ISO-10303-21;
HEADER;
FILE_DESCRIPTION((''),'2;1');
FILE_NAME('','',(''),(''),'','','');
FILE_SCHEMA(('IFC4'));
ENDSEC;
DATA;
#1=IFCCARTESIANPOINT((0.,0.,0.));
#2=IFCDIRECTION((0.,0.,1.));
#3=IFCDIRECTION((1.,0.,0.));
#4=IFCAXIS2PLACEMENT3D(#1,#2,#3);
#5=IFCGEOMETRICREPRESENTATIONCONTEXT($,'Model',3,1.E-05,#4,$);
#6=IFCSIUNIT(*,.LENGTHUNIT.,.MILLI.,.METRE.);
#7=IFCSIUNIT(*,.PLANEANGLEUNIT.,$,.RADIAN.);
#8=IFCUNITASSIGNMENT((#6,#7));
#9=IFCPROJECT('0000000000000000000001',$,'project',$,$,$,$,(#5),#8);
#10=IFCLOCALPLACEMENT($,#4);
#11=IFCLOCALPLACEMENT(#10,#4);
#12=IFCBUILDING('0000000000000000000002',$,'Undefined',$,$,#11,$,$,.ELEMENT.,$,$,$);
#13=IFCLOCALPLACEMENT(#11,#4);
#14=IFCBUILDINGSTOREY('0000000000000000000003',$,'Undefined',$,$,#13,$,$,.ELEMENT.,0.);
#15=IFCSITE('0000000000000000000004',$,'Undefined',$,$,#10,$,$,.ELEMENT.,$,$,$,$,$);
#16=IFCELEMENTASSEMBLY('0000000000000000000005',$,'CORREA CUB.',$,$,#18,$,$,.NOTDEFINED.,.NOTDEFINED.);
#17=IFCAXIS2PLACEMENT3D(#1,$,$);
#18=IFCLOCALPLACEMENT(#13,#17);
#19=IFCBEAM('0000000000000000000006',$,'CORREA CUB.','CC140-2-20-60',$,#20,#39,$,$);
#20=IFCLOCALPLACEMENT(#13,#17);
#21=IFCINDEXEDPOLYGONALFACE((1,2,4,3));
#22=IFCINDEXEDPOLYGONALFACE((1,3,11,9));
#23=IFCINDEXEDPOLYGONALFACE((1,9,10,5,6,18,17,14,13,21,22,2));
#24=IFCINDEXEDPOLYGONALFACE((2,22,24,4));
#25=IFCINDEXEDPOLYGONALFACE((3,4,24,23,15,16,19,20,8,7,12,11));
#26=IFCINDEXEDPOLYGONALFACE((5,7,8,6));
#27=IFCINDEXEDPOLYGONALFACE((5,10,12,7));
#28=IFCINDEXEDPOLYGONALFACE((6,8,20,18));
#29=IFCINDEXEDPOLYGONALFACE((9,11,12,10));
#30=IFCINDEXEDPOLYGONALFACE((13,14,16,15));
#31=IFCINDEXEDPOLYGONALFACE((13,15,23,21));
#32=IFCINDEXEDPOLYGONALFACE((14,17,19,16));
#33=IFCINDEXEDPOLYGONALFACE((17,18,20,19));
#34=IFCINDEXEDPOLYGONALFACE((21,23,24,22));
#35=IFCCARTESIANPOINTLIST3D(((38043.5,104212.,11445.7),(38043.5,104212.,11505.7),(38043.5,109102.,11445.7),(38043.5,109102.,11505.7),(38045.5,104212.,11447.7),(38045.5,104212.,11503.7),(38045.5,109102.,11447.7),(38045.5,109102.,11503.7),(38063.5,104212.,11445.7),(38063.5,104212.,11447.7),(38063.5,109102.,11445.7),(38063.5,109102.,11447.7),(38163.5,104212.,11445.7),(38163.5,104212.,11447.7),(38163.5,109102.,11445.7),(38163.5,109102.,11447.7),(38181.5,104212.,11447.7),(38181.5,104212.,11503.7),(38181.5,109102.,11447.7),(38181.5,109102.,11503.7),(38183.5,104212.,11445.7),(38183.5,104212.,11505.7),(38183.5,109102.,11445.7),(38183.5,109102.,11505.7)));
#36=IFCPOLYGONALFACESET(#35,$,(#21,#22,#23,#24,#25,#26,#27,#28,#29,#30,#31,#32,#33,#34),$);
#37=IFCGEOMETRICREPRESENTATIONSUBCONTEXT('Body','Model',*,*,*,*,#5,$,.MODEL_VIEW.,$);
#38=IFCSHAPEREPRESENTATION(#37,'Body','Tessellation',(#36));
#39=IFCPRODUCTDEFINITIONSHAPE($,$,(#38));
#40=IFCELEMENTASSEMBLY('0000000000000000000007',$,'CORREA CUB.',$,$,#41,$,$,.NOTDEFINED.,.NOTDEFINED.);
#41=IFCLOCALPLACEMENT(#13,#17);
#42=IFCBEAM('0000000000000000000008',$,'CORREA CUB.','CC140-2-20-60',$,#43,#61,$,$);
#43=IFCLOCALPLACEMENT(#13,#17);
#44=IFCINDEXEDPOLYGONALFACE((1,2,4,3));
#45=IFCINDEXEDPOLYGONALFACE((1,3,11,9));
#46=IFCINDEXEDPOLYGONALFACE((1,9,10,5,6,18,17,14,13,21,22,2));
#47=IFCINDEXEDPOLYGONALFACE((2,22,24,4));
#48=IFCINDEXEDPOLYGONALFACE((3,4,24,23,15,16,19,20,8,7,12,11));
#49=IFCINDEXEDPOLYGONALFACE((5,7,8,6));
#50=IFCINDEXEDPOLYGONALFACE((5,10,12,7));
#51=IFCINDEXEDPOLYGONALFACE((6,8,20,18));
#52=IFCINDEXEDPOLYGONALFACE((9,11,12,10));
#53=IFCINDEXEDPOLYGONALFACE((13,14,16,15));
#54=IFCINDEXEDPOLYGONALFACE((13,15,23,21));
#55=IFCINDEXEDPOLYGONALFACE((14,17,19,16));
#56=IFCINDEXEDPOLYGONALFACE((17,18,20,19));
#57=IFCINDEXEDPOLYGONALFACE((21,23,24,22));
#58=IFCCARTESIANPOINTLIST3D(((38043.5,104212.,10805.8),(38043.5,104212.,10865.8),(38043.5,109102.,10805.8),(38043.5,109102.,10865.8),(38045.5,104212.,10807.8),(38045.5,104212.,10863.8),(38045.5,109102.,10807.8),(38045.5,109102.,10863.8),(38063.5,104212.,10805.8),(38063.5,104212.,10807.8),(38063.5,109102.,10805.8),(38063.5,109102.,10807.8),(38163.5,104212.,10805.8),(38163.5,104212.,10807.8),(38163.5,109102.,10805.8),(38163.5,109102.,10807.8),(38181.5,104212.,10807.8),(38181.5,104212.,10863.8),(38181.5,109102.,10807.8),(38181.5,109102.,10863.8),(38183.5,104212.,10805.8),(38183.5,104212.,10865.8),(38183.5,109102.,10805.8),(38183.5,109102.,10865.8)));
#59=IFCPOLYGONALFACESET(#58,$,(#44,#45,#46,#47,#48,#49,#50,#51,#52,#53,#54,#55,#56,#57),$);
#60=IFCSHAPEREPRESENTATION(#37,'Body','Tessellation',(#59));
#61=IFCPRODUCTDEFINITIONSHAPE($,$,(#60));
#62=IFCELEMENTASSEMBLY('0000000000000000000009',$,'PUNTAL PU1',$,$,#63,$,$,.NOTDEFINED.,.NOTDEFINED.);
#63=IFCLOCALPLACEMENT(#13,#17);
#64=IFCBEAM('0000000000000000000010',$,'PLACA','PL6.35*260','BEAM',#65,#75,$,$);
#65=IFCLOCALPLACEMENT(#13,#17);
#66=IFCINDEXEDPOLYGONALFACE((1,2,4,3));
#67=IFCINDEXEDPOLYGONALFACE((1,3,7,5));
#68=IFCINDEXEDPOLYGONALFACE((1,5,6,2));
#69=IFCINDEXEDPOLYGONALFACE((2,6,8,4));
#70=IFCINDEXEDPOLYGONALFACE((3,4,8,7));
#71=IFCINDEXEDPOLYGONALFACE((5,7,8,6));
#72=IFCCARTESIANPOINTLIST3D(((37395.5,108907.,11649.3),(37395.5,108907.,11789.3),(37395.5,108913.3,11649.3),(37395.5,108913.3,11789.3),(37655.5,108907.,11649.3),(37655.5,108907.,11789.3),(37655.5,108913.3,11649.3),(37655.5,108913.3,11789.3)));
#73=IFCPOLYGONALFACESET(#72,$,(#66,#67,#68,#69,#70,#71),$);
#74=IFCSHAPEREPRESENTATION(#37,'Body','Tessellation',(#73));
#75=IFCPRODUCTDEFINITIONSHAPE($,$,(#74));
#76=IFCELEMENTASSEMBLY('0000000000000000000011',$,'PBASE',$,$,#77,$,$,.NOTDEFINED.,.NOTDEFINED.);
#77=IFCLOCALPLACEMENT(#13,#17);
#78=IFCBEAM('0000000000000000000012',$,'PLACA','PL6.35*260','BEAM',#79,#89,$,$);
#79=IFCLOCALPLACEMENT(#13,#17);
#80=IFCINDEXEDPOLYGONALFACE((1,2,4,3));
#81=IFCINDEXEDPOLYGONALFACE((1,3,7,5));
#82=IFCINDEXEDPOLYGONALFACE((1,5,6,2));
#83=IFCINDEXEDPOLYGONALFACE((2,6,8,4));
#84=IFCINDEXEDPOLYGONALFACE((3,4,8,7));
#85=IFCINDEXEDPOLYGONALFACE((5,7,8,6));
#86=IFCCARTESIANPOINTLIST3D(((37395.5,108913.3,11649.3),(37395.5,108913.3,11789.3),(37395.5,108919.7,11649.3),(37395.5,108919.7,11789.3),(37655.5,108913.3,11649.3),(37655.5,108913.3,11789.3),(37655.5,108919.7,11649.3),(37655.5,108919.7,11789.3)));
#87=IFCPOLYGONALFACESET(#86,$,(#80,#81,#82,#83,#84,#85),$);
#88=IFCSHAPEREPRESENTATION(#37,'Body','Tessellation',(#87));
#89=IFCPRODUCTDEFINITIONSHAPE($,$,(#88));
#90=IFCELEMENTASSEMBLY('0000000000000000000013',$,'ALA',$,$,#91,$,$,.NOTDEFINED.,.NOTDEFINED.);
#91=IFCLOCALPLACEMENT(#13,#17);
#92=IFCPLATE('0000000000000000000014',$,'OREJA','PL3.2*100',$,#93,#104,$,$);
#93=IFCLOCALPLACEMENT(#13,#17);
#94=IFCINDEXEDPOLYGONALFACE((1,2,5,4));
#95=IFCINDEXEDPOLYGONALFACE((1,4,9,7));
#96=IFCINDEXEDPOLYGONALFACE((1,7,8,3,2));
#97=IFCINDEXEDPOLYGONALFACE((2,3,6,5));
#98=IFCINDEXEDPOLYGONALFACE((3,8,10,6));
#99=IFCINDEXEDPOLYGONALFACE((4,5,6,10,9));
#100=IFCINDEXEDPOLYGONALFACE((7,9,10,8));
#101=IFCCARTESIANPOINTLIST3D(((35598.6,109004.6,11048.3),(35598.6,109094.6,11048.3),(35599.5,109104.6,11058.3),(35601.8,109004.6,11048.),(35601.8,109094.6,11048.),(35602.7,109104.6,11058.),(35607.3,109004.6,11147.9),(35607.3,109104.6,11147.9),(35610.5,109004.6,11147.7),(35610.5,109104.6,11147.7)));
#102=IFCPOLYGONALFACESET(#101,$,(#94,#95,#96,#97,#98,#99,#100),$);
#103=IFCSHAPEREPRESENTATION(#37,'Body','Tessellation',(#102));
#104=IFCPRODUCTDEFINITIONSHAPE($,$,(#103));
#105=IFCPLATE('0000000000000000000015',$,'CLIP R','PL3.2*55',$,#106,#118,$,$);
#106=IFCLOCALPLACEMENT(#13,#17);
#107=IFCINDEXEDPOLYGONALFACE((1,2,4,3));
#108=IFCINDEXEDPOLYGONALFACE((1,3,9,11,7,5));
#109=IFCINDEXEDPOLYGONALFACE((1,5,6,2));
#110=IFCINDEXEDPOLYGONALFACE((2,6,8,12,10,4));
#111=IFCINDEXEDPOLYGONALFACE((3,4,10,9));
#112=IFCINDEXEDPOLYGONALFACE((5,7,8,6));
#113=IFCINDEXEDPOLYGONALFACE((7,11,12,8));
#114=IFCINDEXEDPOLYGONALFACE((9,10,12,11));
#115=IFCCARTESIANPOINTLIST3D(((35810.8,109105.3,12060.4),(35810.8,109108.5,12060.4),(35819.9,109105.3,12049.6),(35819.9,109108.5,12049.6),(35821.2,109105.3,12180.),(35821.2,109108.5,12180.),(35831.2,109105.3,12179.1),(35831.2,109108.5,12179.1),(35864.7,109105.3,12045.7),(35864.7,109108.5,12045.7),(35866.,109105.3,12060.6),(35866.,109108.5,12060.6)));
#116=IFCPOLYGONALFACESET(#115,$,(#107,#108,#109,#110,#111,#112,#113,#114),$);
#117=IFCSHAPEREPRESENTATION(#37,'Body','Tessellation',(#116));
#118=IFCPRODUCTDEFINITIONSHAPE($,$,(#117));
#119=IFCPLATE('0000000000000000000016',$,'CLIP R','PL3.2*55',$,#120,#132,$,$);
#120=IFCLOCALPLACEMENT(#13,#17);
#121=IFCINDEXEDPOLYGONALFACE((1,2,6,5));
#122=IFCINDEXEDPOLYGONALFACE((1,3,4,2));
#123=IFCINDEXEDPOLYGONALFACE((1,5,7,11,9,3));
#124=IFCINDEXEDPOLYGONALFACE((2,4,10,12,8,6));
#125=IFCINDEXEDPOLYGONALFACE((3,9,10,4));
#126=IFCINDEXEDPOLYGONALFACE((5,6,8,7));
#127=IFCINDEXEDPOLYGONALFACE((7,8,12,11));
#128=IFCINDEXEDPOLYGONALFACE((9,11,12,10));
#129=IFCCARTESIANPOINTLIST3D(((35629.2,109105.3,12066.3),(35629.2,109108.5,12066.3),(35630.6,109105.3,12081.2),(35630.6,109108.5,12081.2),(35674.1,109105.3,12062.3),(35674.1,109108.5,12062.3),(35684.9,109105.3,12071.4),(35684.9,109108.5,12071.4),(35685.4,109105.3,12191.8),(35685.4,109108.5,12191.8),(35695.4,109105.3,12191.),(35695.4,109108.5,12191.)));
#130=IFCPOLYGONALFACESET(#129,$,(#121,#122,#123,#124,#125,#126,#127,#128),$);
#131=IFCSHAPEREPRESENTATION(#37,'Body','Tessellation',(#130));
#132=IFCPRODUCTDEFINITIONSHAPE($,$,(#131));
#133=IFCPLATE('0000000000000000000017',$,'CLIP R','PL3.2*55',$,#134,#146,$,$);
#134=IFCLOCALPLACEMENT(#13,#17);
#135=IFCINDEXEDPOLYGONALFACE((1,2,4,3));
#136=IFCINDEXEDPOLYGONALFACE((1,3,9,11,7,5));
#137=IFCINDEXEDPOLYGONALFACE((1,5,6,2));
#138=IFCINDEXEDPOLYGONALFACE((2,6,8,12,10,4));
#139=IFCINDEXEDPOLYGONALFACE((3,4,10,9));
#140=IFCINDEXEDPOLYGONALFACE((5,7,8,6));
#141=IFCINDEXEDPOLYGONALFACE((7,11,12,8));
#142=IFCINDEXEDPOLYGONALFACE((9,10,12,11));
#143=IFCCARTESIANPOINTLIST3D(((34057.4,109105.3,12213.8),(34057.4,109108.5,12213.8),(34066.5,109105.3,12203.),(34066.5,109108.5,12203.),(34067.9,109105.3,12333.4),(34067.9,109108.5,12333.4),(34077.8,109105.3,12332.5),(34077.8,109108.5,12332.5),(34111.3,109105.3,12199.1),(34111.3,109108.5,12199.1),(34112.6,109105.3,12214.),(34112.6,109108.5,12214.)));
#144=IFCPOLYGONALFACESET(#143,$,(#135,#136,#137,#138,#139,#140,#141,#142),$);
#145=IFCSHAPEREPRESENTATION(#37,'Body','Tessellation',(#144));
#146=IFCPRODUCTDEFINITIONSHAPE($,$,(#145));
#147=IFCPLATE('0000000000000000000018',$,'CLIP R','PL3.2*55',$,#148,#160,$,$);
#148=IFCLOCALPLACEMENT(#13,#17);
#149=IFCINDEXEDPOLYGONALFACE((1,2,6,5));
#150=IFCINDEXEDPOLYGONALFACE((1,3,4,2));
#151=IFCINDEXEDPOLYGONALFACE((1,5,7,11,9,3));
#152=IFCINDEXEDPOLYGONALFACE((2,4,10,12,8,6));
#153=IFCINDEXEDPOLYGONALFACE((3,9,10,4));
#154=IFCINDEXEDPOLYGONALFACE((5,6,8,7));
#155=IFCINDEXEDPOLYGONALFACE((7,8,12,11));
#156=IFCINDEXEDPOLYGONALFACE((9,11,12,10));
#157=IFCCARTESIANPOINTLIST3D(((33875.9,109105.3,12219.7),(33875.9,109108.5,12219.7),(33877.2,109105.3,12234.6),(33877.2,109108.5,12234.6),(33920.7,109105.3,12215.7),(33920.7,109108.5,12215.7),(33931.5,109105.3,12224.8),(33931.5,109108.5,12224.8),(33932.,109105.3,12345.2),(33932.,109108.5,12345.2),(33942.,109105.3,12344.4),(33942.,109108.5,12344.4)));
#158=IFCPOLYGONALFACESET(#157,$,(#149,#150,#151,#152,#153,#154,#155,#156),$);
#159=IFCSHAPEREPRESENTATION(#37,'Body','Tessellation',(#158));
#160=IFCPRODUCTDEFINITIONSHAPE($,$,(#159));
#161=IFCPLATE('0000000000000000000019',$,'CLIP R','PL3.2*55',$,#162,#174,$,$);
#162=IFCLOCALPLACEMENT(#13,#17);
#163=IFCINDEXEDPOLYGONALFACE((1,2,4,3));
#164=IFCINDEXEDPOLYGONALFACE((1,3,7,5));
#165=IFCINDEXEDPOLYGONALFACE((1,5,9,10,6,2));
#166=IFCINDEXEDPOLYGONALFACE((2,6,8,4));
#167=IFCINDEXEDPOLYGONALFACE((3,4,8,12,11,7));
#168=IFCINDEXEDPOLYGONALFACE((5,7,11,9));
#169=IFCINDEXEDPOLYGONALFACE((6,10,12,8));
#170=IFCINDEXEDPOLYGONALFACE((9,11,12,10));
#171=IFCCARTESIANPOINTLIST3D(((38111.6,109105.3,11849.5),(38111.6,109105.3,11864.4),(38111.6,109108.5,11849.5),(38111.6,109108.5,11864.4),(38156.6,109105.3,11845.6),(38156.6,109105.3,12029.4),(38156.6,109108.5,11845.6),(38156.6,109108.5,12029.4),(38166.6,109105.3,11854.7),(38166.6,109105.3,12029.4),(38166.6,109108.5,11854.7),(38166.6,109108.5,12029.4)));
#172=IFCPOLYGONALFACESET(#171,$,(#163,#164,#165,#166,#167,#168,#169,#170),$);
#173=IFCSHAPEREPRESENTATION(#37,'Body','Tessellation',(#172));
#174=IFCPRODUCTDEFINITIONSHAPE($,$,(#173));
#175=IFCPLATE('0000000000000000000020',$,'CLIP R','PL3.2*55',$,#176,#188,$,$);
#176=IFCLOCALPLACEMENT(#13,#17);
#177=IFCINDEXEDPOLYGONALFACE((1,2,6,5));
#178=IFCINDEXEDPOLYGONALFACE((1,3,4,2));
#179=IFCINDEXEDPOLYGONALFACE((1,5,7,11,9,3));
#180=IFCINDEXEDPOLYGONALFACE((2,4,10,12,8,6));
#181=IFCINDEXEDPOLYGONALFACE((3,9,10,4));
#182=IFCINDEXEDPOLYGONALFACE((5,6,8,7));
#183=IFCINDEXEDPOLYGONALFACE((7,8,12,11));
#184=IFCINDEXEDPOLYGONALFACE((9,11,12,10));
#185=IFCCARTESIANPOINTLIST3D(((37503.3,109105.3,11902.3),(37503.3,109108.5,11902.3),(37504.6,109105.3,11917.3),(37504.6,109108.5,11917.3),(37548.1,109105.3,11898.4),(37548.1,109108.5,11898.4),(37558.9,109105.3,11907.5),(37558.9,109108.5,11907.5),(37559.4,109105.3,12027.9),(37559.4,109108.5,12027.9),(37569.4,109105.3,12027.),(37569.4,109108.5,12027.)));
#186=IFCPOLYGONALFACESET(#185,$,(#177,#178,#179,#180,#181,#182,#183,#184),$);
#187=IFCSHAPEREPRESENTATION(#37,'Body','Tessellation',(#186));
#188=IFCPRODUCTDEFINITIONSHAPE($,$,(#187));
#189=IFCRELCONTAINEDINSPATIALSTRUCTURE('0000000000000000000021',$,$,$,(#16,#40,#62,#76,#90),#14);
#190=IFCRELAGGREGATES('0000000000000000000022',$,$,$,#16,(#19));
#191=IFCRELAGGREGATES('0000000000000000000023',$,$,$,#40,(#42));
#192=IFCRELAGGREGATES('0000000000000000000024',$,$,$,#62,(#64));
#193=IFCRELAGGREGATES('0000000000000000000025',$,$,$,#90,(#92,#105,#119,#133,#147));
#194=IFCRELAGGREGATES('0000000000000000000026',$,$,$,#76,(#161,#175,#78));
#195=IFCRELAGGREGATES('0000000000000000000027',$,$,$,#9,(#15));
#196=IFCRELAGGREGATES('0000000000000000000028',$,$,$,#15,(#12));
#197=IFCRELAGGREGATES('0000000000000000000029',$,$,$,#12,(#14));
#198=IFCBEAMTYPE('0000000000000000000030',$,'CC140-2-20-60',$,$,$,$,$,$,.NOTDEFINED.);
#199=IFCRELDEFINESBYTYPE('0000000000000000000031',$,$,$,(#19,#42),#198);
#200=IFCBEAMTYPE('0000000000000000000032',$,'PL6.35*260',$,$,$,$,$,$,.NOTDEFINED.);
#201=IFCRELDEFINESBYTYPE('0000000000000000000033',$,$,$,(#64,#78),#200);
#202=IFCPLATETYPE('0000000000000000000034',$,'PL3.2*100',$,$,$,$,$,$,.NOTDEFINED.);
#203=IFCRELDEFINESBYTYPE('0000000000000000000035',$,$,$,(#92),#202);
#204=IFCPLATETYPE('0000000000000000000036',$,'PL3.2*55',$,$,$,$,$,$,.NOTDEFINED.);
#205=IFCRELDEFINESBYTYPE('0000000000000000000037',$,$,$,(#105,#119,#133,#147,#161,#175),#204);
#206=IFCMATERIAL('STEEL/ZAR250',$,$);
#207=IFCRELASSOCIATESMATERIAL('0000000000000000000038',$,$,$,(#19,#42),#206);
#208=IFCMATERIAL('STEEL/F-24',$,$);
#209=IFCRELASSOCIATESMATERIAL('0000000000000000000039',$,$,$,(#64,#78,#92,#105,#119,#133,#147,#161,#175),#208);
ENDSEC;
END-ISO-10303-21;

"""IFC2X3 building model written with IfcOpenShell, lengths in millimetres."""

from ifc_helpers import new_model, si_unit, frame, origin_with_axes, origin_2d_with_axis, place, context, subcontext, project, spatial, polyline, rectangle, c_section, outline, extrude, material, type_object, element, aggregate, save


model = new_model("IFC2X3")

# Units and contexts
model_context = context("Model", 3, precision=1e-05, world=origin_with_axes())
body_context = subcontext(model_context, "Body", "Model", "MODEL_VIEW")
ifc_project = project(units=[si_unit("LENGTHUNIT", "METRE", prefix="MILLI"), si_unit("PLANEANGLEUNIT", "RADIAN")], contexts=[model_context])

# Site, building, storey
site_placement = place(None, origin_with_axes())
site = spatial("IfcSite", under=ifc_project, at=site_placement, Name="Undefined", CompositionType="ELEMENT")
building_placement = place(site_placement, origin_with_axes())
building = spatial("IfcBuilding", under=site, at=building_placement, Name="Undefined", CompositionType="ELEMENT")
storey_placement = place(building_placement, origin_with_axes())
storey = spatial("IfcBuildingStorey", under=building, at=storey_placement, Name="Undefined", CompositionType="ELEMENT", Elevation=0.0)

# Element assemblies, beams
assembly_1_placement = place(storey_placement, origin_with_axes())
assembly_1 = element("IfcElementAssembly", 1, at=assembly_1_placement, inside=storey, Name="CORREA CUB.", AssemblyPlace="NOTDEFINED", PredefinedType="NOTDEFINED")
ifc_material_1 = material(Name="STEEL/ZAR250")
beam_type_1 = type_object("IfcBeamType", Name="CC140-2-20-60", PredefinedType="NOTDEFINED")
beam_1_placement = place(assembly_1_placement, frame((38113.5, 109102.0, 11475.7), z_axis=(-1.0, 0.0, 0.0), x_axis=(0.0, -1.0, 0.0)))
beam_1 = element("IfcBeam", 2, at=beam_1_placement, type_object=beam_type_1, material=ifc_material_1, Name="CORREA CUB.", Description="CC140-2-20-60", context=body_context, shape_type="SweptSolid", body=[
    extrude(c_section(Depth=140.0, Width=60.0, WallThickness=2.0, Girth=20.0, at=origin_2d_with_axis()), frame((4890.0, 0.0, 0.0), z_axis=(-1.0, 0.0, 0.0), x_axis=(0.0, -1.0, 0.0)), (0.0, 0.0, 1.0), 4890.0),
])
aggregate(assembly_1, [beam_1])
assembly_2_placement = place(storey_placement, origin_with_axes())
assembly_2 = element("IfcElementAssembly", 3, at=assembly_2_placement, inside=storey, Name="CORREA CUB.", AssemblyPlace="NOTDEFINED", PredefinedType="NOTDEFINED")
beam_2_placement = place(assembly_2_placement, frame((38113.5, 109102.0, 10835.8), z_axis=(-1.0, 0.0, 0.0), x_axis=(0.0, -1.0, 0.0)))
beam_2 = element("IfcBeam", 4, at=beam_2_placement, type_object=beam_type_1, material=ifc_material_1, Name="CORREA CUB.", Description="CC140-2-20-60", context=body_context, shape_type="SweptSolid", body=[
    extrude(c_section(Depth=140.0, Width=60.0, WallThickness=2.0, Girth=20.0, at=origin_2d_with_axis()), frame((4890.0, 0.0, 0.0), z_axis=(-1.0, 0.0, 0.0), x_axis=(0.0, -1.0, 0.0)), (0.0, 0.0, 1.0), 4890.0),
])
aggregate(assembly_2, [beam_2])
assembly_3_placement = place(storey_placement, origin_with_axes())
assembly_3 = element("IfcElementAssembly", 5, at=assembly_3_placement, inside=storey, Name="PUNTAL PU1", AssemblyPlace="NOTDEFINED", PredefinedType="NOTDEFINED")
ifc_material_2 = material(Name="STEEL/F-24")
beam_type_2 = type_object("IfcBeamType", Name="PL6.35*260", PredefinedType="NOTDEFINED")
beam_3_placement = place(assembly_3_placement, frame((37525.5, 108910.1, 11649.3), z_axis=(1.0, 0.0, 0.0), x_axis=(0.0, 0.0, 1.0)))
beam_3 = element("IfcBeam", 6, at=beam_3_placement, type_object=beam_type_2, material=ifc_material_2, Name="PLACA", Description="PL6.35*260", ObjectType="BEAM", context=body_context, shape_type="SweptSolid", body=[
    extrude(rectangle(XDim=6.3, YDim=260.0, at=origin_2d_with_axis()), frame((140.0, 0.0, 0.0), z_axis=(-1.0, 0.0, 0.0), x_axis=(0.0, -1.0, 0.0)), (0.0, 0.0, 1.0), 140.0),
])
aggregate(assembly_3, [beam_3])
assembly_4_placement = place(storey_placement, origin_with_axes())
assembly_4 = element("IfcElementAssembly", 7, at=assembly_4_placement, inside=storey, Name="PBASE", AssemblyPlace="NOTDEFINED", PredefinedType="NOTDEFINED")
beam_4_placement = place(assembly_4_placement, frame((37525.5, 108916.5, 11649.3), z_axis=(1.0, 0.0, 0.0), x_axis=(0.0, 0.0, 1.0)))
beam_4 = element("IfcBeam", 8, at=beam_4_placement, type_object=beam_type_2, material=ifc_material_2, Name="PLACA", Description="PL6.35*260", ObjectType="BEAM", context=body_context, shape_type="SweptSolid", body=[
    extrude(rectangle(XDim=6.3, YDim=260.0, at=origin_2d_with_axis()), frame((140.0, 0.0, 0.0), z_axis=(-1.0, 0.0, 0.0), x_axis=(0.0, -1.0, 0.0)), (0.0, 0.0, 1.0), 140.0),
])

# Element assembly, plates
assembly_5_placement = place(storey_placement, origin_with_axes())
assembly_5 = element("IfcElementAssembly", 9, at=assembly_5_placement, inside=storey, Name="ALA", AssemblyPlace="NOTDEFINED", PredefinedType="NOTDEFINED")
plate_type_1 = type_object("IfcPlateType", Name="PL3.2*100", PredefinedType="NOTDEFINED")
plate_1_placement = place(assembly_5_placement, frame((35600.2, 109004.6, 11048.2), z_axis=(0.996195, 0.0, -0.087155), x_axis=(0.0, 1.0, 0.0)))
plate_1 = element("IfcPlate", 10, at=plate_1_placement, type_object=plate_type_1, material=ifc_material_2, Name="OREJA", Description="PL3.2*100", context=body_context, shape_type="SweptSolid", body=[
    extrude(outline(polyline([(0.0, 0.0), (90.0, 0.0), (100.0, 10.0), (100.0, 100.0), (0.0, 100.0), (0.0, 0.0)])), frame((0.0, 0.0, -1.6), z_axis=(0.0, 0.0, 1.0), x_axis=(1.0, 0.0, 0.0)), (0.0, 0.0, 1.0), 3.2),
])
plate_type_2 = type_object("IfcPlateType", Name="PL3.2*55", PredefinedType="NOTDEFINED")
plate_2_placement = place(assembly_5_placement, frame((35821.2, 109106.9, 12180.0), z_axis=(0.0, 1.0, 0.0), x_axis=(0.996195, 0.0, -0.087155)))
plate_2 = element("IfcPlate", 11, at=plate_2_placement, type_object=plate_type_2, material=ifc_material_2, Name="CLIP R", Description="PL3.2*55", context=body_context, shape_type="SweptSolid", body=[
    extrude(outline(polyline([(0.0, 0.0), (10.0, 0.0), (55.0, 115.0), (55.0, 130.0), (10.0, 130.0), (0.0, 120.0), (0.0, 0.0)])), frame((0.0, 0.0, -1.6), z_axis=(0.0, 0.0, 1.0), x_axis=(1.0, 0.0, 0.0)), (0.0, 0.0, 1.0), 3.2),
])
plate_3_placement = place(assembly_5_placement, frame((35695.4, 109106.9, 12191.0), z_axis=(0.0, -1.0, 0.0), x_axis=(-0.996195, 0.0, 0.087155)))
plate_3 = element("IfcPlate", 12, at=plate_3_placement, type_object=plate_type_2, material=ifc_material_2, Name="CLIP R", Description="PL3.2*55", context=body_context, shape_type="SweptSolid", body=[
    extrude(outline(polyline([(0.0, 0.0), (10.0, 0.0), (55.0, 115.0), (55.0, 130.0), (10.0, 130.0), (0.0, 120.0), (0.0, 0.0)])), frame((0.0, 0.0, -1.6), z_axis=(0.0, 0.0, 1.0), x_axis=(1.0, 0.0, 0.0)), (0.0, 0.0, 1.0), 3.2),
])
plate_4_placement = place(assembly_5_placement, frame((34067.9, 109106.9, 12333.4), z_axis=(0.0, 1.0, 0.0), x_axis=(0.996195, 0.0, -0.087155)))
plate_4 = element("IfcPlate", 13, at=plate_4_placement, type_object=plate_type_2, material=ifc_material_2, Name="CLIP R", Description="PL3.2*55", context=body_context, shape_type="SweptSolid", body=[
    extrude(outline(polyline([(0.0, 0.0), (10.0, 0.0), (55.0, 115.0), (55.0, 130.0), (10.0, 130.0), (0.0, 120.0), (0.0, 0.0)])), frame((0.0, 0.0, -1.6), z_axis=(0.0, 0.0, 1.0), x_axis=(1.0, 0.0, 0.0)), (0.0, 0.0, 1.0), 3.2),
])
plate_5_placement = place(assembly_5_placement, frame((33942.0, 109106.9, 12344.4), z_axis=(0.0, -1.0, 0.0), x_axis=(-0.996195, 0.0, 0.087155)))
plate_5 = element("IfcPlate", 14, at=plate_5_placement, type_object=plate_type_2, material=ifc_material_2, Name="CLIP R", Description="PL3.2*55", context=body_context, shape_type="SweptSolid", body=[
    extrude(outline(polyline([(0.0, 0.0), (10.0, 0.0), (55.0, 115.0), (55.0, 130.0), (10.0, 130.0), (0.0, 120.0), (0.0, 0.0)])), frame((0.0, 0.0, -1.6), z_axis=(0.0, 0.0, 1.0), x_axis=(1.0, 0.0, 0.0)), (0.0, 0.0, 1.0), 3.2),
])

# Plates
plate_6_placement = place(assembly_4_placement, frame((38166.6, 109106.9, 12029.4), z_axis=(0.0, -1.0, 0.0), x_axis=(-1.0, 0.0, 0.0)))
plate_6 = element("IfcPlate", 15, at=plate_6_placement, type_object=plate_type_2, material=ifc_material_2, Name="CLIP R", Description="PL3.2*55", context=body_context, shape_type="SweptSolid", body=[
    extrude(outline(polyline([(0.0, 0.0), (10.0, 0.0), (55.0, 165.0), (55.0, 179.8), (10.0, 183.7), (0.0, 174.6), (0.0, 0.0)])), frame((0.0, 0.0, -1.6), z_axis=(0.0, 0.0, 1.0), x_axis=(1.0, 0.0, 0.0)), (0.0, 0.0, 1.0), 3.2),
])
plate_7_placement = place(assembly_4_placement, frame((37569.4, 109106.9, 12027.0), z_axis=(0.0, -1.0, 0.0), x_axis=(-0.996195, 0.0, 0.087155)))
plate_7 = element("IfcPlate", 16, at=plate_7_placement, type_object=plate_type_2, material=ifc_material_2, Name="CLIP R", Description="PL3.2*55", context=body_context, shape_type="SweptSolid", body=[
    extrude(outline(polyline([(0.0, 0.0), (10.0, 0.0), (55.0, 115.0), (55.0, 130.0), (10.0, 130.0), (0.0, 120.0), (0.0, 0.0)])), frame((0.0, 0.0, -1.6), z_axis=(0.0, 0.0, 1.0), x_axis=(1.0, 0.0, 0.0)), (0.0, 0.0, 1.0), 3.2),
])
aggregate(assembly_5, [plate_1, plate_2, plate_3, plate_4, plate_5])

aggregate(assembly_4, [plate_6, plate_7, beam_4])

save(model, "model.ifc")
